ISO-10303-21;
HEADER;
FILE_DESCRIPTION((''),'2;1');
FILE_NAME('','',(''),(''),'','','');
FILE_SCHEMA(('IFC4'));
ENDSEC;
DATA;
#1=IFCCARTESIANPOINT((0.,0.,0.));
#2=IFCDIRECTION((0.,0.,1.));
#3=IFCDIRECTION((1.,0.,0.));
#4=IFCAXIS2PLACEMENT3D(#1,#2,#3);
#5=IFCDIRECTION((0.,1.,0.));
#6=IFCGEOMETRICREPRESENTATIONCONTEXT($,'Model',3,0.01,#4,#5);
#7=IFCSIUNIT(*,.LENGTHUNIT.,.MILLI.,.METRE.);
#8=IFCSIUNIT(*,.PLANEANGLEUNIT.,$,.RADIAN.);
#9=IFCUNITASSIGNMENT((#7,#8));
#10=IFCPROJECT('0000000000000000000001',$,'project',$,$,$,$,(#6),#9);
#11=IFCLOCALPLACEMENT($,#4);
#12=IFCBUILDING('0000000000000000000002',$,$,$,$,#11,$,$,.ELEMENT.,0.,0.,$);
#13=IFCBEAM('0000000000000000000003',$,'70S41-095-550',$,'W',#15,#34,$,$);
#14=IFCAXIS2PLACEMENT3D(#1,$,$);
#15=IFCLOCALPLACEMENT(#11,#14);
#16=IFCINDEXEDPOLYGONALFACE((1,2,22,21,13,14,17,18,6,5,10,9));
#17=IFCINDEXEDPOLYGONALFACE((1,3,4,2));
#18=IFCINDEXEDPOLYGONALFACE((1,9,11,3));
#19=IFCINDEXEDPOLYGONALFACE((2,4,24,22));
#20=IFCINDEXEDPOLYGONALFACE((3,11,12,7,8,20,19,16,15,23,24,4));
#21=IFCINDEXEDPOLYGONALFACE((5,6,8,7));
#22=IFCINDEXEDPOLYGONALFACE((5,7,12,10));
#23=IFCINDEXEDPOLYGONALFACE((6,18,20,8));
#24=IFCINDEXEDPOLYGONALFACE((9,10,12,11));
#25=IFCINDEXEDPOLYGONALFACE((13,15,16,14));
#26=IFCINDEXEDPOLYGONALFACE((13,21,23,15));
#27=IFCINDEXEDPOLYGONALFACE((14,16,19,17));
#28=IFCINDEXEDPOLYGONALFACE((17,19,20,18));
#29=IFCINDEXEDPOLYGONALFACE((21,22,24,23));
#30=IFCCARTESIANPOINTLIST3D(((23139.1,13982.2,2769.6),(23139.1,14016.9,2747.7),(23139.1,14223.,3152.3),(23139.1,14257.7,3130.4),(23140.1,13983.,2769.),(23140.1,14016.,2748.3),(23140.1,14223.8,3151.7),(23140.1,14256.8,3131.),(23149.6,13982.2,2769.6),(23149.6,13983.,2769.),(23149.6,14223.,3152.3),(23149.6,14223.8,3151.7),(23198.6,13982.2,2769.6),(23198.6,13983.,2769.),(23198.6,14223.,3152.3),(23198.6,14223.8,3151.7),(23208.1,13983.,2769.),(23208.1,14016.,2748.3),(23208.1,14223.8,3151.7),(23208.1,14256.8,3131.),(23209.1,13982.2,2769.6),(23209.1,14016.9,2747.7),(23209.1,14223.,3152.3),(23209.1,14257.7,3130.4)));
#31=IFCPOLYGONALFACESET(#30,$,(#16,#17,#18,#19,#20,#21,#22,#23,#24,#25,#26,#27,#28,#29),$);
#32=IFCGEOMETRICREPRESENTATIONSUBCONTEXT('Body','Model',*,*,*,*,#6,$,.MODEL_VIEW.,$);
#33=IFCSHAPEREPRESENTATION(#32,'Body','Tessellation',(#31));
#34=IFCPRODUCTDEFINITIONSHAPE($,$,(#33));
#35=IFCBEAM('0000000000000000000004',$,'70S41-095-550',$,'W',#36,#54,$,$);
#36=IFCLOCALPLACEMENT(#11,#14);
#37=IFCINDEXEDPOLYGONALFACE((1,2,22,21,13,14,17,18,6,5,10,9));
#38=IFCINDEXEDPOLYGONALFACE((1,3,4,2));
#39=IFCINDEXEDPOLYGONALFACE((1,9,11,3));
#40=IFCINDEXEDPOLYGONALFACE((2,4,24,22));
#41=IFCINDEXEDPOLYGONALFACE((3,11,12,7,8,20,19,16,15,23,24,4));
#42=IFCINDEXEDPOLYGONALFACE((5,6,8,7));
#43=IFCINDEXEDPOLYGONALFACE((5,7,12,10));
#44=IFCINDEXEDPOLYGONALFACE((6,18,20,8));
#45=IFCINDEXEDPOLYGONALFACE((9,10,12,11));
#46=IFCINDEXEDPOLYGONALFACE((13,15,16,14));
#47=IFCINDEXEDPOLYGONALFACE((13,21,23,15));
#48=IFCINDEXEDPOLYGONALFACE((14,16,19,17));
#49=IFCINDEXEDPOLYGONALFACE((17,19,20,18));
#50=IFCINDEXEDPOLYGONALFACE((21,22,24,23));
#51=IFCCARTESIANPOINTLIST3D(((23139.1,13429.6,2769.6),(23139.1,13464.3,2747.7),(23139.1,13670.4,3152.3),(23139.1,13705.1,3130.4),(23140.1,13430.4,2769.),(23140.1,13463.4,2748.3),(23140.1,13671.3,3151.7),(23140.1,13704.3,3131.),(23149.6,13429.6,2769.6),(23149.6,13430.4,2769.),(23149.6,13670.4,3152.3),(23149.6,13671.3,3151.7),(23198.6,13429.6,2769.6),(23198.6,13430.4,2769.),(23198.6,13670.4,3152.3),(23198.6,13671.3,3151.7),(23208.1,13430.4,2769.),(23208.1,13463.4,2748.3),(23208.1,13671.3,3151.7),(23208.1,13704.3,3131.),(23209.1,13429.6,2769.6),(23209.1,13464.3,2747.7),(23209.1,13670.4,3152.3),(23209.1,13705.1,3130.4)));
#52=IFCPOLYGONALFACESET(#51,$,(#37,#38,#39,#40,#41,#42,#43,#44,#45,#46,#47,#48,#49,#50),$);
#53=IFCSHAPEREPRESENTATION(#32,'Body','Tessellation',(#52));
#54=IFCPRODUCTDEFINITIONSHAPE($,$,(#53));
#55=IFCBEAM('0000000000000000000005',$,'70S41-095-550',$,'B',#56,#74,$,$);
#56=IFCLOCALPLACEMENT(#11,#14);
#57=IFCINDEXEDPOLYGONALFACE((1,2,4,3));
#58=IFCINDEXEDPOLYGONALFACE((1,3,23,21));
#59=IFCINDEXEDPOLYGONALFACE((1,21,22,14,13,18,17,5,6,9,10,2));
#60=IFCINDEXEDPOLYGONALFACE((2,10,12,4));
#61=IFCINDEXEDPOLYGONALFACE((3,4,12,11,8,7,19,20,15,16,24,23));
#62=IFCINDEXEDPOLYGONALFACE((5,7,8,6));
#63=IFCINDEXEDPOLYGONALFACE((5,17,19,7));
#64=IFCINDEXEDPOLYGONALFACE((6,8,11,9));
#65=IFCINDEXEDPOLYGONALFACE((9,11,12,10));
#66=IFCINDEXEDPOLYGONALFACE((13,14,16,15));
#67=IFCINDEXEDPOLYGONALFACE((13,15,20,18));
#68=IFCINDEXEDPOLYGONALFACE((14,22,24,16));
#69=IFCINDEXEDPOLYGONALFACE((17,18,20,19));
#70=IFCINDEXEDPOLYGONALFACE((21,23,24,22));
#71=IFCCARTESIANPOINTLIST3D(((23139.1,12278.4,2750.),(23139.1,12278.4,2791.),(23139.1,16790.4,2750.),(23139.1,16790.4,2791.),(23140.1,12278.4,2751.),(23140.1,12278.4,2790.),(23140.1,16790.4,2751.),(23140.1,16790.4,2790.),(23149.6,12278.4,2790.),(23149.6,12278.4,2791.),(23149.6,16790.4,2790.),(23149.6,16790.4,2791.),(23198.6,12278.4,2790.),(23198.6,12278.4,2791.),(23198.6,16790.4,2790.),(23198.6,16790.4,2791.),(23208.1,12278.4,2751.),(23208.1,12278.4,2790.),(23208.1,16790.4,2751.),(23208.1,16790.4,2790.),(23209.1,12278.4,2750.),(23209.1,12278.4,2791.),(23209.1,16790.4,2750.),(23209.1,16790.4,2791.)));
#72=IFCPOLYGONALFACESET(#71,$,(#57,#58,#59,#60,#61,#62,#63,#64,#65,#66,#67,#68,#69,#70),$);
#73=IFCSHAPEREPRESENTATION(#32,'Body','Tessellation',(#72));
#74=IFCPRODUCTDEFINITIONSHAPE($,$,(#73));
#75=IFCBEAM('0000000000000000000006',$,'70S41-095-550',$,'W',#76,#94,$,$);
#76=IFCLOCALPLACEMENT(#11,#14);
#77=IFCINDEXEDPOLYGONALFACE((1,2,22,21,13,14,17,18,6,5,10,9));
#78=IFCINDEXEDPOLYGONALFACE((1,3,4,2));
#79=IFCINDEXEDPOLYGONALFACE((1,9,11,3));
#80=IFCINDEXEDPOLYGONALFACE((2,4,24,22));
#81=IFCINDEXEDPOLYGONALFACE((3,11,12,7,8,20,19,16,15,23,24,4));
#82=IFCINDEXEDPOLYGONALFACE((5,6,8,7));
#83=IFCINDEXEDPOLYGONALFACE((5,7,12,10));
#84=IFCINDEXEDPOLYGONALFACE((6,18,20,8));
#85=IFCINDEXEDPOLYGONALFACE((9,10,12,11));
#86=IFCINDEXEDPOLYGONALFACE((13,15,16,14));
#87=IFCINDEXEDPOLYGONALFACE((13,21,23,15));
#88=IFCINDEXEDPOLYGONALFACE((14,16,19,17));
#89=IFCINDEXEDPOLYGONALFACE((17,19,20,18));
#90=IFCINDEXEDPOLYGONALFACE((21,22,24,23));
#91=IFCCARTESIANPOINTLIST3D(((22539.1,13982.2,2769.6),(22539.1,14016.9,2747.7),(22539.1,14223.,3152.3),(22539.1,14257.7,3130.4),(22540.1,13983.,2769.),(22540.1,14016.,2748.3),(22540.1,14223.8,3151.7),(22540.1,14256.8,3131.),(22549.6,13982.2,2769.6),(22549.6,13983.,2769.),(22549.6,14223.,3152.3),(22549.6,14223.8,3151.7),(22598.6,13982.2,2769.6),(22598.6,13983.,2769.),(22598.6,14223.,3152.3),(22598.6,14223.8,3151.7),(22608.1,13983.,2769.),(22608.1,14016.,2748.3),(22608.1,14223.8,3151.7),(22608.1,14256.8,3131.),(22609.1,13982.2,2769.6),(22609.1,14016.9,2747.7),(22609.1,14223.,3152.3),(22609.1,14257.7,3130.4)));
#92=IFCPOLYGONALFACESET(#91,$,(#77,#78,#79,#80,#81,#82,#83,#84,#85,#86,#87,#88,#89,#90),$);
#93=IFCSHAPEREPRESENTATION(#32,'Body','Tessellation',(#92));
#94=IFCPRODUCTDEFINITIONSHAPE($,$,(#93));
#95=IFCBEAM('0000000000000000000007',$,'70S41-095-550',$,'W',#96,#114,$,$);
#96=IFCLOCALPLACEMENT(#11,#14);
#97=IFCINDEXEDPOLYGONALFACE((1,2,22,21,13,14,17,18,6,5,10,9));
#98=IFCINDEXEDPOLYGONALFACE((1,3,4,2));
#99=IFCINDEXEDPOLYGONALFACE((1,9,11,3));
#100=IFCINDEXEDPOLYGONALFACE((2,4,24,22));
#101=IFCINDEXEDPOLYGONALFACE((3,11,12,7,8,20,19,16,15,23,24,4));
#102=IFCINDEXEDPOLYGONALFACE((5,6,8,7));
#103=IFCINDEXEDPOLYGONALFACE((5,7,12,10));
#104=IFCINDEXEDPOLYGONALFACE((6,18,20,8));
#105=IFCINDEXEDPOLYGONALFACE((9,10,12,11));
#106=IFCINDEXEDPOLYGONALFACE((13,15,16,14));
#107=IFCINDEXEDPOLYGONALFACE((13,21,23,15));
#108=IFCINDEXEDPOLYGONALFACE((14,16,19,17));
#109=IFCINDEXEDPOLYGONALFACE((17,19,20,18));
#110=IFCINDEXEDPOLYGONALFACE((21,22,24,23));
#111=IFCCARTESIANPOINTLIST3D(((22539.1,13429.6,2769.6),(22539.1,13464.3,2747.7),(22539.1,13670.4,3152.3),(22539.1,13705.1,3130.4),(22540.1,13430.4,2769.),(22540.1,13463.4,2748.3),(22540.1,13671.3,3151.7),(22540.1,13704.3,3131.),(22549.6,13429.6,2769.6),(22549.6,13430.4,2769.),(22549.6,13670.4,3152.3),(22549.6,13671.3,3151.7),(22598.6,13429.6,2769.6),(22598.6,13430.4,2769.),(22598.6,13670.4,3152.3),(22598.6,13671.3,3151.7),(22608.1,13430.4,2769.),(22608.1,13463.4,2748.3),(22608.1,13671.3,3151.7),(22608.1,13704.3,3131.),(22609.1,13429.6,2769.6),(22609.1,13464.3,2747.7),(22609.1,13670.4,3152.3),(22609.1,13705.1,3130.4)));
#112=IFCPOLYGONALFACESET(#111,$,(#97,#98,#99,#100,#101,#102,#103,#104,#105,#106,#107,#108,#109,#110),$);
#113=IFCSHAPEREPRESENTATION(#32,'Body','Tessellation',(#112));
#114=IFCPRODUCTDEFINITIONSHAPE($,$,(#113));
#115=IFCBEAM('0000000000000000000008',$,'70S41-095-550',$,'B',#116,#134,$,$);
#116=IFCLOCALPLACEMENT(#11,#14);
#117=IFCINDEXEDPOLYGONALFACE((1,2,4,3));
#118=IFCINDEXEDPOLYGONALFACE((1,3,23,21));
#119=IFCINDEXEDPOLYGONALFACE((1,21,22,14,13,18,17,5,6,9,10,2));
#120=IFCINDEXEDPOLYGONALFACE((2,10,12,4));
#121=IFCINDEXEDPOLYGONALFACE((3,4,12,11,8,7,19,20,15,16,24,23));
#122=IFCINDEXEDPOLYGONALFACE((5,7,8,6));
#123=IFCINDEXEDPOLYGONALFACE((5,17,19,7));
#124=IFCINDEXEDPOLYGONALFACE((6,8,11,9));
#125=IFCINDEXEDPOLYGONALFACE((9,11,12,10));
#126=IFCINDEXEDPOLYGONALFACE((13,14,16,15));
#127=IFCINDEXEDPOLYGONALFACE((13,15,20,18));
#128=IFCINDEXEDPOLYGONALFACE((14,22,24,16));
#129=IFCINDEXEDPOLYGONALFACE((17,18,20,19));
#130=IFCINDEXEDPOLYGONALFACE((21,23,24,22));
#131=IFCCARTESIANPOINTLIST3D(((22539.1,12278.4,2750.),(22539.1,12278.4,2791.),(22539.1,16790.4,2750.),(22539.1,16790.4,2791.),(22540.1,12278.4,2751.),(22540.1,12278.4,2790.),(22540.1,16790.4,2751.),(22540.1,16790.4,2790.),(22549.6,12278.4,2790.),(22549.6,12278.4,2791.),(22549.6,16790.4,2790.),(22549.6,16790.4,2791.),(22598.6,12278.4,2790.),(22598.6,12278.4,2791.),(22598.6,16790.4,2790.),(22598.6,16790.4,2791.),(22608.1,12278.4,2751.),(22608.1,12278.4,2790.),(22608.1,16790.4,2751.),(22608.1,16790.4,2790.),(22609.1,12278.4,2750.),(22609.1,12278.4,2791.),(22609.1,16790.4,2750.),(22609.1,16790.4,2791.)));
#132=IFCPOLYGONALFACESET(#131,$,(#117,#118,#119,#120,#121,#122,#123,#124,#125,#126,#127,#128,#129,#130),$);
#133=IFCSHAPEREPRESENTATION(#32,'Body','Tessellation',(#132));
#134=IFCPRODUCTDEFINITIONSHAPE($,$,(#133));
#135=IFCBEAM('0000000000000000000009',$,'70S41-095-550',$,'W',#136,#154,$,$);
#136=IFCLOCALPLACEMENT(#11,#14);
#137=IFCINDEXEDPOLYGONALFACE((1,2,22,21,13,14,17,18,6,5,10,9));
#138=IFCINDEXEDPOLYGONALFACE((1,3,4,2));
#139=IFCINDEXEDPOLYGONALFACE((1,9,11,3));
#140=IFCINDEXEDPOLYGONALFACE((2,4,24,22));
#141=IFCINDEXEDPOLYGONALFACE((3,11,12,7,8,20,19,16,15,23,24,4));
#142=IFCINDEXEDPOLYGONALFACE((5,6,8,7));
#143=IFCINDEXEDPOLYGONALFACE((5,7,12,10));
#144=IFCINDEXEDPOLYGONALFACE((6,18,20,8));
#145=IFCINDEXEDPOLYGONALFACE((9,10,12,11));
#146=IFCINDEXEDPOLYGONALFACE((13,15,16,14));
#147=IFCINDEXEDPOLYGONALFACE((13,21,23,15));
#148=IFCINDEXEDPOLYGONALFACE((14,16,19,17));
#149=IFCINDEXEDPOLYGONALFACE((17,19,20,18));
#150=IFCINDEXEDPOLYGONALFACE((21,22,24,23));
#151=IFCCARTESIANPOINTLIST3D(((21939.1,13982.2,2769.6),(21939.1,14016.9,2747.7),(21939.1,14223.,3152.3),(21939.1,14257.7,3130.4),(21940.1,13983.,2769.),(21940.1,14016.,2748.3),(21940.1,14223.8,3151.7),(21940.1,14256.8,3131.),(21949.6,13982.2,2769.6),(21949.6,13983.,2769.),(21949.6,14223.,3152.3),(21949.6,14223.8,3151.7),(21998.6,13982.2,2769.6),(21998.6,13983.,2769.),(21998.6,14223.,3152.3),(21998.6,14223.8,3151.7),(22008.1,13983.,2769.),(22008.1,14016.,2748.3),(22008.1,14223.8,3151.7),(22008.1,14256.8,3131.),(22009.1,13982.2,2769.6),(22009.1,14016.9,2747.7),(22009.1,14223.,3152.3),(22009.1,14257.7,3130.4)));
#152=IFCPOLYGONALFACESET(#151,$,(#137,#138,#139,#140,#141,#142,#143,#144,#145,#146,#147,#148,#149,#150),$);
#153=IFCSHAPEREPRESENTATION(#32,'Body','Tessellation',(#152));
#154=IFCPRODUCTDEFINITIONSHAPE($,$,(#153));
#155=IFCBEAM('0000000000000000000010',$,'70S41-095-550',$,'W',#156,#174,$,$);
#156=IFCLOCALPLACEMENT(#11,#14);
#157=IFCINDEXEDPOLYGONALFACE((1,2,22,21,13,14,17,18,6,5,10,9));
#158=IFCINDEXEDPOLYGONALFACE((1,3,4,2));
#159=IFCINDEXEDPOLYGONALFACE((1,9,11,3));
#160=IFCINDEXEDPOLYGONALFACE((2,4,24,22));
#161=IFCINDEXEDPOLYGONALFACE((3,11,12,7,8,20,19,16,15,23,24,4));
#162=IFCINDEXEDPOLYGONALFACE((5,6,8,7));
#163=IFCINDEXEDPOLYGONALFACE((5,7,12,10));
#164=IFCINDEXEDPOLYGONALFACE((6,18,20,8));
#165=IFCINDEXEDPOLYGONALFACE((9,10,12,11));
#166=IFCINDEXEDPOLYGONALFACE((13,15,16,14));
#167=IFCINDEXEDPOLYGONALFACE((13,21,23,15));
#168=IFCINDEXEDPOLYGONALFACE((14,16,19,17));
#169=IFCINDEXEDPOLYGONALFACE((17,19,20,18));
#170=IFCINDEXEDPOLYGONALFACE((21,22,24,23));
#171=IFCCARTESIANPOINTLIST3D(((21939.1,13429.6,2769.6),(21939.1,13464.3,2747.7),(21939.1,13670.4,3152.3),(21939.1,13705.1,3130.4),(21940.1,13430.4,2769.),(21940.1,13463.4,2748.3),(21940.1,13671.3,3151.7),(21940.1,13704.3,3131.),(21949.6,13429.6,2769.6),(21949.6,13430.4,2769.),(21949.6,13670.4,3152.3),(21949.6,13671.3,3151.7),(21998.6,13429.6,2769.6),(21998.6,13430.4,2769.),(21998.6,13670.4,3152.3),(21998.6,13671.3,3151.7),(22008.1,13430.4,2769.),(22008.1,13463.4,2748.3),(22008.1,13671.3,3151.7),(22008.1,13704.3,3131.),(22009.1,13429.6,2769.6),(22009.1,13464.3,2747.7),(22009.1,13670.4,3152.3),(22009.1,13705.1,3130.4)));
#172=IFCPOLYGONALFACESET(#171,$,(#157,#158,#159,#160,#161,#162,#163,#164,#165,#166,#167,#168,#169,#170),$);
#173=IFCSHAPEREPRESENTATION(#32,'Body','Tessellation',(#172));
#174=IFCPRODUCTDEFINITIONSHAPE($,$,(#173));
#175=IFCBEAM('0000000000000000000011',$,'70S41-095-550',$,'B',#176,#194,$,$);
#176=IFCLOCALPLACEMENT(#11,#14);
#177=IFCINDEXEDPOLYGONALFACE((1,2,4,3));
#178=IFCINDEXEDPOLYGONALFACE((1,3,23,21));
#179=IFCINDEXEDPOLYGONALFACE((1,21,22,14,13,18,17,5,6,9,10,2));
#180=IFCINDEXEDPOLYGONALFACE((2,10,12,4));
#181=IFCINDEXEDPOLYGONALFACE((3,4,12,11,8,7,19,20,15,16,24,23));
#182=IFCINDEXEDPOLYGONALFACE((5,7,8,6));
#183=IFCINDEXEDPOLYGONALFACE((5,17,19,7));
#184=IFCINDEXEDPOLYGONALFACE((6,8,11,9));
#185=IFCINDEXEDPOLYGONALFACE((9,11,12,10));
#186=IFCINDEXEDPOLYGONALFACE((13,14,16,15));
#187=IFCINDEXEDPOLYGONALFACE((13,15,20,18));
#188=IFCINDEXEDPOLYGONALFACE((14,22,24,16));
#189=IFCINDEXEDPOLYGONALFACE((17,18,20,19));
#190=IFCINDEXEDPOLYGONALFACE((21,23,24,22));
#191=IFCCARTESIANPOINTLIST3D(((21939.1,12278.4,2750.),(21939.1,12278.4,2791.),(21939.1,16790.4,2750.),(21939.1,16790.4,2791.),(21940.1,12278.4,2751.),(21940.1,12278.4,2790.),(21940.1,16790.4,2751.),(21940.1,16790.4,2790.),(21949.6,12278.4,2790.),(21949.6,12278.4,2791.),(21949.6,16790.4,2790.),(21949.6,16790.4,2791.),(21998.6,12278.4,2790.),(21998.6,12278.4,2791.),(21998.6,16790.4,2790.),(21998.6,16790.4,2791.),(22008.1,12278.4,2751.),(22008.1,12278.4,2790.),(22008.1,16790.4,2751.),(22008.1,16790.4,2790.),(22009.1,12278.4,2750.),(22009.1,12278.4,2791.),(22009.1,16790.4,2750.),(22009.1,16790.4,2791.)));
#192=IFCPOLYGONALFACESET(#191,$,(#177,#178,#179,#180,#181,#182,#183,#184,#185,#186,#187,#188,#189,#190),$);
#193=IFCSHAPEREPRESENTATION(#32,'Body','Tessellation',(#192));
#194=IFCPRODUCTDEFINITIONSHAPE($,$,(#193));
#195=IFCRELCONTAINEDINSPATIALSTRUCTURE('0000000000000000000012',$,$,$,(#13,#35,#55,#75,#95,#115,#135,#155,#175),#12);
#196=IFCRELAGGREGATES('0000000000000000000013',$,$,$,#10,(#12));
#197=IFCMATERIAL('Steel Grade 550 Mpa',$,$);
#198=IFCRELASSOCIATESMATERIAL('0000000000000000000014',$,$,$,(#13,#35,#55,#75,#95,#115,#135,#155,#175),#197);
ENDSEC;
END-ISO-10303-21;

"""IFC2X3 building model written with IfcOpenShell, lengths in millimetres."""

from ifc_helpers import new_model, si_unit, direction, frame, origin, origin_with_axes, origin_2d_with_axis, place, context, subcontext, project, spatial, c_section, extrude, source, transform, mapped, material, element, save


model = new_model("IFC2X3")

# Units and contexts
model_context = context("Model", 3, precision=0.01, world=origin_with_axes(), true_north=direction((0.0, 1.0, 0.0)))
body_context = subcontext(model_context, "Body", "Model", "MODEL_VIEW")
ifc_project = project(units=[si_unit("LENGTHUNIT", "METRE", prefix="MILLI"), si_unit("PLANEANGLEUNIT", "RADIAN")], contexts=[model_context])

# Building
building_placement = place(None, origin_with_axes())
building = spatial("IfcBuilding", under=ifc_project, at=building_placement, CompositionType="ELEMENT", ElevationOfRefHeight=0.0, ElevationOfTerrain=0.0)

# Beams
ifc_material = material(Name="Steel Grade 550 Mpa")
shared_shape_1 = source(origin(), body_context, "Body", "SweptSolid", [
    extrude(c_section(Depth=70.0, Width=41.0, WallThickness=1.0, Girth=10.5, at=origin_2d_with_axis()), origin_with_axes(), (0.0, 0.0, 1.0), 452.2),
])
beam_1_placement = place(None, frame((23174.1, 13999.5, 2758.7), z_axis=(0.0, 0.532581, 0.846379), x_axis=(0.0, -0.846379, 0.532581)))
element("IfcBeam", 1, at=beam_1_placement, inside=building, material=ifc_material, Name="70S41-095-550", ObjectType="W", context=body_context, shape_type="MappedRepresentation", body=[
    mapped(shared_shape_1, transform((0.0, 0.0, 0.0), scale=1.0)),
])
shared_shape_2 = source(origin(), body_context, "Body", "SweptSolid", [
    extrude(c_section(Depth=70.0, Width=41.0, WallThickness=1.0, Girth=10.5, at=origin_2d_with_axis()), origin_with_axes(), (0.0, 0.0, 1.0), 452.2),
])
beam_2_placement = place(None, frame((23174.1, 13446.9, 2758.7), z_axis=(0.0, 0.532581, 0.846379), x_axis=(0.0, -0.846379, 0.532581)))
element("IfcBeam", 2, at=beam_2_placement, inside=building, material=ifc_material, Name="70S41-095-550", ObjectType="W", context=body_context, shape_type="MappedRepresentation", body=[
    mapped(shared_shape_2, transform((0.0, 0.0, 0.0), scale=1.0)),
])
shared_shape_3 = source(origin(), body_context, "Body", "SweptSolid", [
    extrude(c_section(Depth=70.0, Width=41.0, WallThickness=1.0, Girth=10.5, at=origin_2d_with_axis()), origin_with_axes(), (0.0, 0.0, 1.0), 4512.0),
])
beam_3_placement = place(None, frame((23174.1, 12278.4, 2770.5), z_axis=(0.0, 1.0, 0.0), x_axis=(0.0, 0.0, 1.0)))
element("IfcBeam", 3, at=beam_3_placement, inside=building, material=ifc_material, Name="70S41-095-550", ObjectType="B", context=body_context, shape_type="MappedRepresentation", body=[
    mapped(shared_shape_3, transform((0.0, 0.0, 0.0), scale=1.0)),
])
shared_shape_4 = source(origin(), body_context, "Body", "SweptSolid", [
    extrude(c_section(Depth=70.0, Width=41.0, WallThickness=1.0, Girth=10.5, at=origin_2d_with_axis()), origin_with_axes(), (0.0, 0.0, 1.0), 452.2),
])
beam_4_placement = place(None, frame((22574.1, 13999.5, 2758.7), z_axis=(0.0, 0.532581, 0.846379), x_axis=(0.0, -0.846379, 0.532581)))
element("IfcBeam", 4, at=beam_4_placement, inside=building, material=ifc_material, Name="70S41-095-550", ObjectType="W", context=body_context, shape_type="MappedRepresentation", body=[
    mapped(shared_shape_4, transform((0.0, 0.0, 0.0), scale=1.0)),
])
shared_shape_5 = source(origin(), body_context, "Body", "SweptSolid", [
    extrude(c_section(Depth=70.0, Width=41.0, WallThickness=1.0, Girth=10.5, at=origin_2d_with_axis()), origin_with_axes(), (0.0, 0.0, 1.0), 452.2),
])
beam_5_placement = place(None, frame((22574.1, 13446.9, 2758.7), z_axis=(0.0, 0.532581, 0.846379), x_axis=(0.0, -0.846379, 0.532581)))
element("IfcBeam", 5, at=beam_5_placement, inside=building, material=ifc_material, Name="70S41-095-550", ObjectType="W", context=body_context, shape_type="MappedRepresentation", body=[
    mapped(shared_shape_5, transform((0.0, 0.0, 0.0), scale=1.0)),
])
shared_shape_6 = source(origin(), body_context, "Body", "SweptSolid", [
    extrude(c_section(Depth=70.0, Width=41.0, WallThickness=1.0, Girth=10.5, at=origin_2d_with_axis()), origin_with_axes(), (0.0, 0.0, 1.0), 4512.0),
])
beam_6_placement = place(None, frame((22574.1, 12278.4, 2770.5), z_axis=(0.0, 1.0, 0.0), x_axis=(0.0, 0.0, 1.0)))
element("IfcBeam", 6, at=beam_6_placement, inside=building, material=ifc_material, Name="70S41-095-550", ObjectType="B", context=body_context, shape_type="MappedRepresentation", body=[
    mapped(shared_shape_6, transform((0.0, 0.0, 0.0), scale=1.0)),
])
shared_shape_7 = source(origin(), body_context, "Body", "SweptSolid", [
    extrude(c_section(Depth=70.0, Width=41.0, WallThickness=1.0, Girth=10.5, at=origin_2d_with_axis()), origin_with_axes(), (0.0, 0.0, 1.0), 452.2),
])
beam_7_placement = place(None, frame((21974.1, 13999.5, 2758.7), z_axis=(0.0, 0.532581, 0.846379), x_axis=(0.0, -0.846379, 0.532581)))
element("IfcBeam", 7, at=beam_7_placement, inside=building, material=ifc_material, Name="70S41-095-550", ObjectType="W", context=body_context, shape_type="MappedRepresentation", body=[
    mapped(shared_shape_7, transform((0.0, 0.0, 0.0), scale=1.0)),
])
shared_shape_8 = source(origin(), body_context, "Body", "SweptSolid", [
    extrude(c_section(Depth=70.0, Width=41.0, WallThickness=1.0, Girth=10.5, at=origin_2d_with_axis()), origin_with_axes(), (0.0, 0.0, 1.0), 452.2),
])
beam_8_placement = place(None, frame((21974.1, 13446.9, 2758.7), z_axis=(0.0, 0.532581, 0.846379), x_axis=(0.0, -0.846379, 0.532581)))
element("IfcBeam", 8, at=beam_8_placement, inside=building, material=ifc_material, Name="70S41-095-550", ObjectType="W", context=body_context, shape_type="MappedRepresentation", body=[
    mapped(shared_shape_8, transform((0.0, 0.0, 0.0), scale=1.0)),
])
shared_shape_9 = source(origin(), body_context, "Body", "SweptSolid", [
    extrude(c_section(Depth=70.0, Width=41.0, WallThickness=1.0, Girth=10.5, at=origin_2d_with_axis()), origin_with_axes(), (0.0, 0.0, 1.0), 4512.0),
])
beam_9_placement = place(None, frame((21974.1, 12278.4, 2770.5), z_axis=(0.0, 1.0, 0.0), x_axis=(0.0, 0.0, 1.0)))
element("IfcBeam", 9, at=beam_9_placement, inside=building, material=ifc_material, Name="70S41-095-550", ObjectType="B", context=body_context, shape_type="MappedRepresentation", body=[
    mapped(shared_shape_9, transform((0.0, 0.0, 0.0), scale=1.0)),
])

save(model, "model.ifc")
